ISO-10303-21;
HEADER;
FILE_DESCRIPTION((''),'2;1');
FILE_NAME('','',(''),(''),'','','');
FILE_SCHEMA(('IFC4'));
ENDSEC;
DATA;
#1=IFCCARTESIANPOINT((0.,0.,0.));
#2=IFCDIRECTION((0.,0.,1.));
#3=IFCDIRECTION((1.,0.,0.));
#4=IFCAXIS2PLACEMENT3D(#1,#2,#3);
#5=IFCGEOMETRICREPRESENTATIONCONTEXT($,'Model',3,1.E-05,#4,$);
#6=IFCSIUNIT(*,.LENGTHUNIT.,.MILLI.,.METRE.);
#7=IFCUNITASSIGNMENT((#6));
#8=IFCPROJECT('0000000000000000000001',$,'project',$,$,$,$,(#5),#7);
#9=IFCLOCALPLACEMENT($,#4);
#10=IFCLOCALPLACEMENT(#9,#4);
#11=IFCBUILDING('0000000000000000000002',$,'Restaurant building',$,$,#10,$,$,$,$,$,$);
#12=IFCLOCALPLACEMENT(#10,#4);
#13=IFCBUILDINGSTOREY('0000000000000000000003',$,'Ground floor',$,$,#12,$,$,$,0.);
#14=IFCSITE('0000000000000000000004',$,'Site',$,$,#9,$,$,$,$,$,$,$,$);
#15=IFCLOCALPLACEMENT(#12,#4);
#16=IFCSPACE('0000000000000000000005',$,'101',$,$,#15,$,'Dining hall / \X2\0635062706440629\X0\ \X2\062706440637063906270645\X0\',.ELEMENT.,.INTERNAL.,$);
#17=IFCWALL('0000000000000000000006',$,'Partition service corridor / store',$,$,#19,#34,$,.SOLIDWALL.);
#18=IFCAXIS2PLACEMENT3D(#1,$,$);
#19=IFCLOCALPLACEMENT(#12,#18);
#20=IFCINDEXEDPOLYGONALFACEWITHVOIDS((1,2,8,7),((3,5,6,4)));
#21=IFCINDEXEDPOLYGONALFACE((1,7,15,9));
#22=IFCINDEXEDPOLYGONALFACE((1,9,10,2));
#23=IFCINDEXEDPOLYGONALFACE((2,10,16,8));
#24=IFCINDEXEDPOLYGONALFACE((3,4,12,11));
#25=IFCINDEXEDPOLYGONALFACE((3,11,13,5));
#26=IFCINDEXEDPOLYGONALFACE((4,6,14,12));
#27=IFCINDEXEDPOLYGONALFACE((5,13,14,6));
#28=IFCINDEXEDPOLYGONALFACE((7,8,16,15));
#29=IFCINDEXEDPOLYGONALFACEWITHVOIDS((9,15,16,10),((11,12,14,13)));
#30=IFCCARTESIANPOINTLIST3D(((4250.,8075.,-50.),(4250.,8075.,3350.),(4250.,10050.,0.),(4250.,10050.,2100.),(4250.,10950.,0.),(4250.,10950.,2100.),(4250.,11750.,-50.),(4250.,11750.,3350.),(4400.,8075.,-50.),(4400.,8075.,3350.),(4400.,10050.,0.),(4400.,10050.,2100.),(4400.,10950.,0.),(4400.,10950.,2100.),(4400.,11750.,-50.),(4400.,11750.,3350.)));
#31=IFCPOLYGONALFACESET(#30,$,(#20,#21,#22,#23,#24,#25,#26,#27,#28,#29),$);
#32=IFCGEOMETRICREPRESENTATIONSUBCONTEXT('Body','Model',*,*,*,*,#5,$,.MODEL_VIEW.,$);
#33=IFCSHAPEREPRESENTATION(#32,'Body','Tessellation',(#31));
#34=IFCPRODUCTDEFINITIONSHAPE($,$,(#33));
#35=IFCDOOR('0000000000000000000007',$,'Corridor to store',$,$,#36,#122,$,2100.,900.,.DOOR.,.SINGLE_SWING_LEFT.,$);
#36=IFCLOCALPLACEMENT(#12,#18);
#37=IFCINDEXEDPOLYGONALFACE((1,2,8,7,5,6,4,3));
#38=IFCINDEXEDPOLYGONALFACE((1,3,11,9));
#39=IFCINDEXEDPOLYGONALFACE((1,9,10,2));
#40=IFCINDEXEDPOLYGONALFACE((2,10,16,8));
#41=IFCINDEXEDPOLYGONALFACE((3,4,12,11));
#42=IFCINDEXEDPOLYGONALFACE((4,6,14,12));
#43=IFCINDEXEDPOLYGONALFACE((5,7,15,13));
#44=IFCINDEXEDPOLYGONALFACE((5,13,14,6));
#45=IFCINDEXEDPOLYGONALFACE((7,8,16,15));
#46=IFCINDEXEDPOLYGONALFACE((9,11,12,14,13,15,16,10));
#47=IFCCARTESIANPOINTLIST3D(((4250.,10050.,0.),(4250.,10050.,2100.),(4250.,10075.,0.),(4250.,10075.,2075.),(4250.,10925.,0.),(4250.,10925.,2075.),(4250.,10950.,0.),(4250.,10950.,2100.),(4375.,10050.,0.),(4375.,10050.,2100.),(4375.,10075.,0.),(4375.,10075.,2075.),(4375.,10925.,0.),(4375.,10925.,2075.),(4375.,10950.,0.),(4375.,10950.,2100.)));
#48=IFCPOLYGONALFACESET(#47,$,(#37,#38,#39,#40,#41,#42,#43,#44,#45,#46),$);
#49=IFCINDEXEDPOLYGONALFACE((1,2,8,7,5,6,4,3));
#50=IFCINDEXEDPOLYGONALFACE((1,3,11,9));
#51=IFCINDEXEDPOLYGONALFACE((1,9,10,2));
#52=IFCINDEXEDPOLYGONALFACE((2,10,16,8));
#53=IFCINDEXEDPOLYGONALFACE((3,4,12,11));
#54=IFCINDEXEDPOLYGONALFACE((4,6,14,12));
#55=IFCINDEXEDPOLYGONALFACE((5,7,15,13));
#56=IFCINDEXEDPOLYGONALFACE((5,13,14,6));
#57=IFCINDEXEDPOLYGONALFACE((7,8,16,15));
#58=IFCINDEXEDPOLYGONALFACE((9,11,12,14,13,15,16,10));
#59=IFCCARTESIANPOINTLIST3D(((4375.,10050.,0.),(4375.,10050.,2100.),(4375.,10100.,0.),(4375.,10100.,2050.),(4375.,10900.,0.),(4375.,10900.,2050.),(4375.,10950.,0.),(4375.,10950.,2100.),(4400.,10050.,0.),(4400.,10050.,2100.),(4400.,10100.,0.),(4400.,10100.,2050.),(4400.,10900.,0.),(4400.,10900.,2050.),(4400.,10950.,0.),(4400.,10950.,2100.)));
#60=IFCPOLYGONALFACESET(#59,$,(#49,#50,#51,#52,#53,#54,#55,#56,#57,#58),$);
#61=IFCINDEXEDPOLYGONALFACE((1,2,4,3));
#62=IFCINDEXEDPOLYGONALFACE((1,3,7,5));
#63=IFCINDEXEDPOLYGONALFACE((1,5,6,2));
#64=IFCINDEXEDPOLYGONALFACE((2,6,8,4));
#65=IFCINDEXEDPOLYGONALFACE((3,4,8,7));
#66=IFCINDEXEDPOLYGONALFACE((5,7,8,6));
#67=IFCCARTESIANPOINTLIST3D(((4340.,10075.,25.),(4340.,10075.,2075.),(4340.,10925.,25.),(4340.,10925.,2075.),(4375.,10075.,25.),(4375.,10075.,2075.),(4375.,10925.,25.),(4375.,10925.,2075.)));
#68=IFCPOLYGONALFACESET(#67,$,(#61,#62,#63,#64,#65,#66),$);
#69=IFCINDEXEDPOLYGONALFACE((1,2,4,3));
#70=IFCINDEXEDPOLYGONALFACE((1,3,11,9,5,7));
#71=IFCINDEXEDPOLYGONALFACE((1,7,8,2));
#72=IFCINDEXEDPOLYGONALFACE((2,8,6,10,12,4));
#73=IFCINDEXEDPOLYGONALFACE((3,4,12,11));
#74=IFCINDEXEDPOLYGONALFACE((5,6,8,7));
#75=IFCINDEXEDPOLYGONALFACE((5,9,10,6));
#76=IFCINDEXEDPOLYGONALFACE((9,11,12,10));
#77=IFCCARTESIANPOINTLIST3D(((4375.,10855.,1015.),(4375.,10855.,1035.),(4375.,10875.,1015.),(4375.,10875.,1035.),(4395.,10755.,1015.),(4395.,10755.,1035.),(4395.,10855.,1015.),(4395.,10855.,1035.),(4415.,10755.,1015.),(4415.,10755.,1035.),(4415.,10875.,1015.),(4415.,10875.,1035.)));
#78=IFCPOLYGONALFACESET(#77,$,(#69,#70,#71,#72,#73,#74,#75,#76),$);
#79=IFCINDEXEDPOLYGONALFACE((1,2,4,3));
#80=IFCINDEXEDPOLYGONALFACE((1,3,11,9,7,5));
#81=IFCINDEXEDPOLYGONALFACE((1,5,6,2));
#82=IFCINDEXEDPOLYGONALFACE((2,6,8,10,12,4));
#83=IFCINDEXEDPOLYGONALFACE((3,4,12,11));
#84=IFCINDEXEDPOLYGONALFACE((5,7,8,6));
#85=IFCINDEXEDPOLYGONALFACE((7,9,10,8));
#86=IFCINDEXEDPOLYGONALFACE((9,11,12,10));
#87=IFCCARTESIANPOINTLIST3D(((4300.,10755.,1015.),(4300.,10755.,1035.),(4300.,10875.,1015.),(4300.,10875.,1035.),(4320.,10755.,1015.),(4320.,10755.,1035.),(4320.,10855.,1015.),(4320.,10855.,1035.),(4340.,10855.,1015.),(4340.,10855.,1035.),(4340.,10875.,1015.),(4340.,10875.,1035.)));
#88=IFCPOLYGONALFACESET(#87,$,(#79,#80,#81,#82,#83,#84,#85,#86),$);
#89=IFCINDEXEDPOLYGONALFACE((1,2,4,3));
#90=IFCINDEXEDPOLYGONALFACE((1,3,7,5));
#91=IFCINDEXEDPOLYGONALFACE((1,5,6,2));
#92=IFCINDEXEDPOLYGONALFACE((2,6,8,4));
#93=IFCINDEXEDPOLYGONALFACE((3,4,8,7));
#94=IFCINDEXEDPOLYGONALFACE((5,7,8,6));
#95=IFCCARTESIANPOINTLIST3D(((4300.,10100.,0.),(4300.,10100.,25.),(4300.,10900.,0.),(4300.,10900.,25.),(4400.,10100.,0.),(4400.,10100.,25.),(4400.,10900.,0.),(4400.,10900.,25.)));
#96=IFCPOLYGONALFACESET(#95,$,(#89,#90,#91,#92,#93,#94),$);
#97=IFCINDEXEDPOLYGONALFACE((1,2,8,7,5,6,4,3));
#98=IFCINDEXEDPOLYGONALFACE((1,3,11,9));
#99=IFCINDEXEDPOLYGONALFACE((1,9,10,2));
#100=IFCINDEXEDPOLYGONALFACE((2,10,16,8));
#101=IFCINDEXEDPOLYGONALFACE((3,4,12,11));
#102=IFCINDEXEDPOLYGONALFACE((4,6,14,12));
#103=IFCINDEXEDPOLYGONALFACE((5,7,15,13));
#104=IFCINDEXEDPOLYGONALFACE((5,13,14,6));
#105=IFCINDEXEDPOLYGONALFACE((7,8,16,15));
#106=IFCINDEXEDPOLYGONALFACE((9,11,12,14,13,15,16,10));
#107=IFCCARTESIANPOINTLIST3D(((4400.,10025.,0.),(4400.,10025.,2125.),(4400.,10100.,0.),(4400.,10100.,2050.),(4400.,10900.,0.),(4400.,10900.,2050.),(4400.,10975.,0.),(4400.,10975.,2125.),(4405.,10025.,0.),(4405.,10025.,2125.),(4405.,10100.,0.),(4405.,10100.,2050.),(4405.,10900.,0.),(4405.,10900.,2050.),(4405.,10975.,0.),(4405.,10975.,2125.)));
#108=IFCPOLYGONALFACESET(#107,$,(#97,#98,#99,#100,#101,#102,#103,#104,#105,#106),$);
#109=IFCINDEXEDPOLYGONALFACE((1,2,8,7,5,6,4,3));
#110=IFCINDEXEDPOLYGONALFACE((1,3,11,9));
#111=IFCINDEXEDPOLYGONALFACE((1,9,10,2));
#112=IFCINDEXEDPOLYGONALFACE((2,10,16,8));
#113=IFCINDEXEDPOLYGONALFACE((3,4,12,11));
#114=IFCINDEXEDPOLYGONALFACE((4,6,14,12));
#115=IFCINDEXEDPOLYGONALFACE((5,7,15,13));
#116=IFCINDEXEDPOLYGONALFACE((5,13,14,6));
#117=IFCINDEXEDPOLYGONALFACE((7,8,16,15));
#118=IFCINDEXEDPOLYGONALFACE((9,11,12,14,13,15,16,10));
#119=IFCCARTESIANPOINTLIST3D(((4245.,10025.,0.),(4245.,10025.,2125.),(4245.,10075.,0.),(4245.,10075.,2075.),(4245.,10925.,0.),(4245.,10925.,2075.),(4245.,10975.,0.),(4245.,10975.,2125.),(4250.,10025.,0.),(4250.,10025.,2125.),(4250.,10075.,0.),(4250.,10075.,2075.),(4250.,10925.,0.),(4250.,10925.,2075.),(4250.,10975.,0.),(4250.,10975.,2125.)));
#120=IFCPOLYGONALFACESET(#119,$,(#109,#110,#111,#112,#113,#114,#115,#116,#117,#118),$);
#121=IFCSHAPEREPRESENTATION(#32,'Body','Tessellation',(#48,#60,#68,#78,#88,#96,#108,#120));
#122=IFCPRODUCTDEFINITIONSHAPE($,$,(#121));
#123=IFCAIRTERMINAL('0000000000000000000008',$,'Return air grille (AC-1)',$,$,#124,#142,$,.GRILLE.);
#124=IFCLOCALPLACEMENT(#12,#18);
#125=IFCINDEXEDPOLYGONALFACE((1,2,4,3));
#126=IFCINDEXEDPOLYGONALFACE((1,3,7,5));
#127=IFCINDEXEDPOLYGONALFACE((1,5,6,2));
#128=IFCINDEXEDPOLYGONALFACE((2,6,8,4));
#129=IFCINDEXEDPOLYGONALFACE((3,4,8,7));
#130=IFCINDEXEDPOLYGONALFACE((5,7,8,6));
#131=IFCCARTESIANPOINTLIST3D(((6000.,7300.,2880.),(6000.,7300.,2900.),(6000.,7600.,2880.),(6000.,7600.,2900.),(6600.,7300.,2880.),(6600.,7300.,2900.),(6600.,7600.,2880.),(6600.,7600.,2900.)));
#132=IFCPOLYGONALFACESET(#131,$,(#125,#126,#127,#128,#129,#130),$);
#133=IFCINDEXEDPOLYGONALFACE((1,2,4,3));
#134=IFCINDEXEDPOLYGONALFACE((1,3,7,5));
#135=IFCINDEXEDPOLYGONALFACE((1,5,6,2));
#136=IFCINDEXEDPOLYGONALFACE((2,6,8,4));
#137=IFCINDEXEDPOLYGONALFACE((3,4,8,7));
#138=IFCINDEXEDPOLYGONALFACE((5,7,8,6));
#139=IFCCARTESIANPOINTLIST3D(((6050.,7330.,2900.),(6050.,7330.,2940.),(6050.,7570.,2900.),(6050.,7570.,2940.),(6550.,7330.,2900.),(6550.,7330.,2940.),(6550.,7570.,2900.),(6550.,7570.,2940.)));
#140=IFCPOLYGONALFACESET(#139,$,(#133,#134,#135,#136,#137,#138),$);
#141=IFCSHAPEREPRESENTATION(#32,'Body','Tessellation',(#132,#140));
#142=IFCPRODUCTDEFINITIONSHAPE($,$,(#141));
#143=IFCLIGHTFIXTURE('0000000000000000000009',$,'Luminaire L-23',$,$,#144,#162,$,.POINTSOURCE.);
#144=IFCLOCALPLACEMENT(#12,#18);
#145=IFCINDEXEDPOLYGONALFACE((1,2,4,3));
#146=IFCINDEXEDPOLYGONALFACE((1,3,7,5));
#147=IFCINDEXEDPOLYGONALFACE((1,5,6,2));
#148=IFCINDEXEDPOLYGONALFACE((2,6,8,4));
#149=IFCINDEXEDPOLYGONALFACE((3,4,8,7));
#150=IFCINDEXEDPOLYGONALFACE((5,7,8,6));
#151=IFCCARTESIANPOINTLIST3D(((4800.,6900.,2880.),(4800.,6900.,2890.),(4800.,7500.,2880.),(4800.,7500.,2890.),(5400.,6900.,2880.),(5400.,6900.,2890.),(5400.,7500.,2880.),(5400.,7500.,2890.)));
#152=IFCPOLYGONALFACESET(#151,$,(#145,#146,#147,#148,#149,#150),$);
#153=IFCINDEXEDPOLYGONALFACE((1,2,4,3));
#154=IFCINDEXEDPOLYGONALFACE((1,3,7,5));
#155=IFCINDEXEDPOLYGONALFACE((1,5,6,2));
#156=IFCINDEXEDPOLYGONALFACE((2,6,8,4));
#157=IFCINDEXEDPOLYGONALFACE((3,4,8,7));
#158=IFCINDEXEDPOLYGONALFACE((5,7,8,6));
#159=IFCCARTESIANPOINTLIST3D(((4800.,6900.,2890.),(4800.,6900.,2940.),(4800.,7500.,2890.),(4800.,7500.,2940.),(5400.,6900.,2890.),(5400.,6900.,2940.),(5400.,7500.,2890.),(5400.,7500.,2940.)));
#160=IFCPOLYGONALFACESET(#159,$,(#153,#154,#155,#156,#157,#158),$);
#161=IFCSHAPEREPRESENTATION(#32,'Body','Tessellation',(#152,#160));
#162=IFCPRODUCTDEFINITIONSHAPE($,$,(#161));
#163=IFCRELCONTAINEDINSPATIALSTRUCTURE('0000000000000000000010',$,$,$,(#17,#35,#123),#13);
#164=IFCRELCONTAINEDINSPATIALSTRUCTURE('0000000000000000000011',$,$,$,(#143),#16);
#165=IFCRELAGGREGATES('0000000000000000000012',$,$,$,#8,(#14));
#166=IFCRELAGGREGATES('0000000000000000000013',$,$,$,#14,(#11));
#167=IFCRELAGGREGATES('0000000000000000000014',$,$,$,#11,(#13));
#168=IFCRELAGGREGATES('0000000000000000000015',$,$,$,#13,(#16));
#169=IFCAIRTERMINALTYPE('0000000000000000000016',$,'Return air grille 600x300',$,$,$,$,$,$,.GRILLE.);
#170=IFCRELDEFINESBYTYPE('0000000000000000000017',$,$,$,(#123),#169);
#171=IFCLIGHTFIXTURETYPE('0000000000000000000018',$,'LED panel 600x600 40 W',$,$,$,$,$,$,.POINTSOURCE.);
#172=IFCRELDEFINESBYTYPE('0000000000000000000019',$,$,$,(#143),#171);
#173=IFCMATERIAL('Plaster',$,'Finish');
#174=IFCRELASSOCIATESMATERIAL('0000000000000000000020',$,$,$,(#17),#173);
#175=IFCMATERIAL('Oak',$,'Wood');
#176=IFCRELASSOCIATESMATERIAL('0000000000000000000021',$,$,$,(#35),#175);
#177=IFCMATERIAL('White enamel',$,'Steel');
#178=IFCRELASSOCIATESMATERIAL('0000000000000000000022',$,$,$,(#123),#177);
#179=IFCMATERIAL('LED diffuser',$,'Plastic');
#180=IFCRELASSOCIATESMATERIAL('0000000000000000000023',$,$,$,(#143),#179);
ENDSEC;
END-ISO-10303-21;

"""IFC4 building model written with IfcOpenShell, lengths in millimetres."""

from ifc_helpers import new_model, si_unit, frame, origin, origin_with_axes, origin_2d, place, context, subcontext, project, spatial, line, indexed_curve, rectangle, outline, extrude, source, transform, mapped, material, type_object, type_shapes, element, fill, save


model = new_model("IFC4")

# Units and contexts
model_context = context("Model", 3, precision=1e-05, world=origin_with_axes())
body_context = subcontext(model_context, "Body", "Model", "MODEL_VIEW")
ifc_project = project(units=[si_unit("LENGTHUNIT", "METRE", prefix="MILLI")], contexts=[model_context])

# Site, building, storey
site_placement = place(None, origin_with_axes())
site = spatial("IfcSite", under=ifc_project, at=site_placement, Name="Site")
building_placement = place(site_placement, origin_with_axes())
building = spatial("IfcBuilding", under=site, at=building_placement, Name="Restaurant building")
storey_placement = place(building_placement, origin_with_axes())
storey = spatial("IfcBuildingStorey", under=building, at=storey_placement, Name="Ground floor", Elevation=0.0)

# Wall, opening, door
ifc_material_1 = material(Name="Plaster", Category="Finish")
wall_placement = place(storey_placement, frame((4325.0, 8075.0, 0.0), z_axis=(0.0, 0.0, 1.0), x_axis=(0.0, 1.0, 0.0)))
wall = element("IfcWall", 1, at=wall_placement, inside=storey, material=ifc_material_1, Name="Partition service corridor / store", PredefinedType="SOLIDWALL", context=body_context, shape_type="SweptSolid", body=[
    extrude(rectangle(XDim=3675.0, YDim=150.0, at=origin_2d()), frame((1837.5, 0.0, -50.0)), (0.0, 0.0, 1.0), 3400.0),
])
opening_placement = place(wall_placement, frame((1975.0, -75.0, 0.0), z_axis=(0.0, 0.0, 1.0), x_axis=(1.0, 0.0, 0.0)))
opening = element("IfcOpeningElement", 2, at=opening_placement, cuts=wall, PredefinedType="OPENING", context=body_context, shape_type="SweptSolid", body=[
    extrude(rectangle(XDim=900.0, YDim=250.0, at=origin_2d()), frame((450.0, 75.0, 0.0)), (0.0, 0.0, 1.0), 2100.0),
])
ifc_material_2 = material(Name="Oak", Category="Wood")
door_placement = place(storey_placement, frame((4400.0, 10050.0, 0.0), z_axis=(0.0, 0.0, 1.0), x_axis=(0.0, 1.0, 0.0)))
door = element("IfcDoor", 3, at=door_placement, inside=storey, material=ifc_material_2, Name="Corridor to store", OperationType="SINGLE_SWING_LEFT", OverallHeight=2100.0, OverallWidth=900.0, PredefinedType="DOOR", context=body_context, shape_type="SweptSolid", body=[
    extrude(outline(indexed_curve([(0.0, 0.0), (0.0, 2100.0), (900.0, 2100.0), (900.0, 0.0), (875.0, 0.0), (875.0, 2075.0), (25.0, 2075.0), (25.0, 0.0)], segments=[line(1, 2, 3, 4, 5, 6, 7, 8, 1)])), frame((0.0, 25.0, 0.0), z_axis=(0.0, -1.0, 0.0), x_axis=(1.0, 0.0, 0.0)), (0.0, 0.0, -1.0), 125.0),
    extrude(outline(indexed_curve([(0.0, 0.0), (0.0, 2100.0), (900.0, 2100.0), (900.0, 0.0), (850.0, 0.0), (850.0, 2050.0), (50.0, 2050.0), (50.0, 0.0)], segments=[line(1, 2, 3, 4, 5, 6, 7, 8, 1)])), frame((0.0, 0.0, 0.0), z_axis=(0.0, -1.0, 0.0), x_axis=(1.0, 0.0, 0.0)), (0.0, 0.0, -1.0), 25.0),
    extrude(outline(indexed_curve([(0.0, 0.0), (850.0, 0.0), (850.0, 35.0), (0.0, 35.0)], segments=[line(1, 2, 3, 4, 1)])), frame((25.0, 25.0, 25.0), z_axis=(0.0, 0.0, 1.0), x_axis=(1.0, 0.0, 0.0)), (0.0, 0.0, 1.0), 2050.0),
    extrude(outline(indexed_curve([(0.0, 0.0), (0.0, -40.0), (-120.0, -40.0), (-120.0, -20.0), (-20.0, -20.0), (-20.0, 0.0)], segments=[line(1, 2, 3, 4, 5, 6, 1)])), frame((825.0, 25.0, 1015.0), z_axis=(0.0, 0.0, 1.0), x_axis=(1.0, 0.0, 0.0)), (0.0, 0.0, 1.0), 20.0),
    extrude(outline(indexed_curve([(0.0, 0.0), (0.0, 40.0), (-120.0, 40.0), (-120.0, 20.0), (-20.0, 20.0), (-20.0, 0.0)], segments=[line(1, 2, 3, 4, 5, 6, 1)])), frame((825.0, 60.0, 1015.0), z_axis=(0.0, 0.0, 1.0), x_axis=(1.0, 0.0, 0.0)), (0.0, 0.0, 1.0), 20.0),
    extrude(outline(indexed_curve([(0.0, 0.0), (800.0, 0.0), (800.0, 100.0), (0.0, 100.0)], segments=[line(1, 2, 3, 4, 1)])), frame((50.0, 0.0, 0.0), z_axis=(0.0, 0.0, 1.0), x_axis=(1.0, 0.0, 0.0)), (0.0, 0.0, 1.0), 25.0),
    extrude(outline(indexed_curve([(0.0, 0.0), (0.0, 2125.0), (950.0, 2125.0), (950.0, 0.0), (875.0, 0.0), (875.0, 2050.0), (75.0, 2050.0), (75.0, 0.0)], segments=[line(1, 2, 3, 4, 5, 6, 7, 8, 1)])), frame((-25.0, -5.0, 0.0), z_axis=(0.0, -1.0, 0.0), x_axis=(1.0, 0.0, 0.0)), (0.0, 0.0, -1.0), 5.0),
    extrude(outline(indexed_curve([(0.0, 0.0), (0.0, 2125.0), (950.0, 2125.0), (950.0, 0.0), (900.0, 0.0), (900.0, 2075.0), (50.0, 2075.0), (50.0, 0.0)], segments=[line(1, 2, 3, 4, 5, 6, 7, 8, 1)])), frame((-25.0, 150.0, 0.0), z_axis=(0.0, -1.0, 0.0), x_axis=(1.0, 0.0, 0.0)), (0.0, 0.0, -1.0), 5.0),
])
fill(opening, door)

# Air terminal
ifc_material_3 = material(Name="White enamel", Category="Steel")
air_terminal_type = type_object("IfcAirTerminalType", Name="Return air grille 600x300", PredefinedType="GRILLE")
shared_shape_1 = source(origin(), body_context, "Body", "SweptSolid", [
    extrude(rectangle(XDim=600.0, YDim=300.0, at=origin_2d()), frame((0.0, 0.0, -60.0)), (0.0, 0.0, 1.0), 20.0),
    extrude(rectangle(XDim=500.0, YDim=240.0, at=origin_2d()), frame((0.0, 0.0, -40.0)), (0.0, 0.0, 1.0), 40.0),
])
type_shapes(air_terminal_type, [shared_shape_1])
air_terminal_placement = place(storey_placement, frame((6300.0, 7450.0, 2940.0)))
element("IfcAirTerminal", 4, at=air_terminal_placement, inside=storey, type_object=air_terminal_type, material=ifc_material_3, Name="Return air grille (AC-1)", PredefinedType="GRILLE", context=body_context, shape_type="MappedRepresentation", body=[
    mapped(shared_shape_1, transform((0.0, 0.0, 0.0))),
])

# Shared definitions
space_1_placement = place(storey_placement, origin_with_axes())
space_1 = spatial("IfcSpace", under=storey, at=space_1_placement, Name="101", LongName="Dining hall / صالة الطعام", CompositionType="ELEMENT", PredefinedType="INTERNAL")

# Light fixture
ifc_material_4 = material(Name="LED diffuser", Category="Plastic")
light_fixture_type_1 = type_object("IfcLightFixtureType", Name="LED panel 600x600 40 W", PredefinedType="POINTSOURCE")
shared_shape_2 = source(origin(), body_context, "Body", "SweptSolid", [
    extrude(rectangle(XDim=600.0, YDim=600.0, at=origin_2d()), frame((0.0, 0.0, -60.0)), (0.0, 0.0, 1.0), 10.0),
    extrude(rectangle(XDim=600.0, YDim=600.0, at=origin_2d()), frame((0.0, 0.0, -50.0)), (0.0, 0.0, 1.0), 50.0),
])
type_shapes(light_fixture_type_1, [shared_shape_2])
light_fixture_1_placement = place(storey_placement, frame((5100.0, 7200.0, 2940.0)))
element("IfcLightFixture", 5, at=light_fixture_1_placement, inside=space_1, type_object=light_fixture_type_1, material=ifc_material_4, Name="Luminaire L-23", PredefinedType="POINTSOURCE", context=body_context, shape_type="MappedRepresentation", body=[
    mapped(shared_shape_2, transform((0.0, 0.0, 0.0))),
])

save(model, "model.ifc")
